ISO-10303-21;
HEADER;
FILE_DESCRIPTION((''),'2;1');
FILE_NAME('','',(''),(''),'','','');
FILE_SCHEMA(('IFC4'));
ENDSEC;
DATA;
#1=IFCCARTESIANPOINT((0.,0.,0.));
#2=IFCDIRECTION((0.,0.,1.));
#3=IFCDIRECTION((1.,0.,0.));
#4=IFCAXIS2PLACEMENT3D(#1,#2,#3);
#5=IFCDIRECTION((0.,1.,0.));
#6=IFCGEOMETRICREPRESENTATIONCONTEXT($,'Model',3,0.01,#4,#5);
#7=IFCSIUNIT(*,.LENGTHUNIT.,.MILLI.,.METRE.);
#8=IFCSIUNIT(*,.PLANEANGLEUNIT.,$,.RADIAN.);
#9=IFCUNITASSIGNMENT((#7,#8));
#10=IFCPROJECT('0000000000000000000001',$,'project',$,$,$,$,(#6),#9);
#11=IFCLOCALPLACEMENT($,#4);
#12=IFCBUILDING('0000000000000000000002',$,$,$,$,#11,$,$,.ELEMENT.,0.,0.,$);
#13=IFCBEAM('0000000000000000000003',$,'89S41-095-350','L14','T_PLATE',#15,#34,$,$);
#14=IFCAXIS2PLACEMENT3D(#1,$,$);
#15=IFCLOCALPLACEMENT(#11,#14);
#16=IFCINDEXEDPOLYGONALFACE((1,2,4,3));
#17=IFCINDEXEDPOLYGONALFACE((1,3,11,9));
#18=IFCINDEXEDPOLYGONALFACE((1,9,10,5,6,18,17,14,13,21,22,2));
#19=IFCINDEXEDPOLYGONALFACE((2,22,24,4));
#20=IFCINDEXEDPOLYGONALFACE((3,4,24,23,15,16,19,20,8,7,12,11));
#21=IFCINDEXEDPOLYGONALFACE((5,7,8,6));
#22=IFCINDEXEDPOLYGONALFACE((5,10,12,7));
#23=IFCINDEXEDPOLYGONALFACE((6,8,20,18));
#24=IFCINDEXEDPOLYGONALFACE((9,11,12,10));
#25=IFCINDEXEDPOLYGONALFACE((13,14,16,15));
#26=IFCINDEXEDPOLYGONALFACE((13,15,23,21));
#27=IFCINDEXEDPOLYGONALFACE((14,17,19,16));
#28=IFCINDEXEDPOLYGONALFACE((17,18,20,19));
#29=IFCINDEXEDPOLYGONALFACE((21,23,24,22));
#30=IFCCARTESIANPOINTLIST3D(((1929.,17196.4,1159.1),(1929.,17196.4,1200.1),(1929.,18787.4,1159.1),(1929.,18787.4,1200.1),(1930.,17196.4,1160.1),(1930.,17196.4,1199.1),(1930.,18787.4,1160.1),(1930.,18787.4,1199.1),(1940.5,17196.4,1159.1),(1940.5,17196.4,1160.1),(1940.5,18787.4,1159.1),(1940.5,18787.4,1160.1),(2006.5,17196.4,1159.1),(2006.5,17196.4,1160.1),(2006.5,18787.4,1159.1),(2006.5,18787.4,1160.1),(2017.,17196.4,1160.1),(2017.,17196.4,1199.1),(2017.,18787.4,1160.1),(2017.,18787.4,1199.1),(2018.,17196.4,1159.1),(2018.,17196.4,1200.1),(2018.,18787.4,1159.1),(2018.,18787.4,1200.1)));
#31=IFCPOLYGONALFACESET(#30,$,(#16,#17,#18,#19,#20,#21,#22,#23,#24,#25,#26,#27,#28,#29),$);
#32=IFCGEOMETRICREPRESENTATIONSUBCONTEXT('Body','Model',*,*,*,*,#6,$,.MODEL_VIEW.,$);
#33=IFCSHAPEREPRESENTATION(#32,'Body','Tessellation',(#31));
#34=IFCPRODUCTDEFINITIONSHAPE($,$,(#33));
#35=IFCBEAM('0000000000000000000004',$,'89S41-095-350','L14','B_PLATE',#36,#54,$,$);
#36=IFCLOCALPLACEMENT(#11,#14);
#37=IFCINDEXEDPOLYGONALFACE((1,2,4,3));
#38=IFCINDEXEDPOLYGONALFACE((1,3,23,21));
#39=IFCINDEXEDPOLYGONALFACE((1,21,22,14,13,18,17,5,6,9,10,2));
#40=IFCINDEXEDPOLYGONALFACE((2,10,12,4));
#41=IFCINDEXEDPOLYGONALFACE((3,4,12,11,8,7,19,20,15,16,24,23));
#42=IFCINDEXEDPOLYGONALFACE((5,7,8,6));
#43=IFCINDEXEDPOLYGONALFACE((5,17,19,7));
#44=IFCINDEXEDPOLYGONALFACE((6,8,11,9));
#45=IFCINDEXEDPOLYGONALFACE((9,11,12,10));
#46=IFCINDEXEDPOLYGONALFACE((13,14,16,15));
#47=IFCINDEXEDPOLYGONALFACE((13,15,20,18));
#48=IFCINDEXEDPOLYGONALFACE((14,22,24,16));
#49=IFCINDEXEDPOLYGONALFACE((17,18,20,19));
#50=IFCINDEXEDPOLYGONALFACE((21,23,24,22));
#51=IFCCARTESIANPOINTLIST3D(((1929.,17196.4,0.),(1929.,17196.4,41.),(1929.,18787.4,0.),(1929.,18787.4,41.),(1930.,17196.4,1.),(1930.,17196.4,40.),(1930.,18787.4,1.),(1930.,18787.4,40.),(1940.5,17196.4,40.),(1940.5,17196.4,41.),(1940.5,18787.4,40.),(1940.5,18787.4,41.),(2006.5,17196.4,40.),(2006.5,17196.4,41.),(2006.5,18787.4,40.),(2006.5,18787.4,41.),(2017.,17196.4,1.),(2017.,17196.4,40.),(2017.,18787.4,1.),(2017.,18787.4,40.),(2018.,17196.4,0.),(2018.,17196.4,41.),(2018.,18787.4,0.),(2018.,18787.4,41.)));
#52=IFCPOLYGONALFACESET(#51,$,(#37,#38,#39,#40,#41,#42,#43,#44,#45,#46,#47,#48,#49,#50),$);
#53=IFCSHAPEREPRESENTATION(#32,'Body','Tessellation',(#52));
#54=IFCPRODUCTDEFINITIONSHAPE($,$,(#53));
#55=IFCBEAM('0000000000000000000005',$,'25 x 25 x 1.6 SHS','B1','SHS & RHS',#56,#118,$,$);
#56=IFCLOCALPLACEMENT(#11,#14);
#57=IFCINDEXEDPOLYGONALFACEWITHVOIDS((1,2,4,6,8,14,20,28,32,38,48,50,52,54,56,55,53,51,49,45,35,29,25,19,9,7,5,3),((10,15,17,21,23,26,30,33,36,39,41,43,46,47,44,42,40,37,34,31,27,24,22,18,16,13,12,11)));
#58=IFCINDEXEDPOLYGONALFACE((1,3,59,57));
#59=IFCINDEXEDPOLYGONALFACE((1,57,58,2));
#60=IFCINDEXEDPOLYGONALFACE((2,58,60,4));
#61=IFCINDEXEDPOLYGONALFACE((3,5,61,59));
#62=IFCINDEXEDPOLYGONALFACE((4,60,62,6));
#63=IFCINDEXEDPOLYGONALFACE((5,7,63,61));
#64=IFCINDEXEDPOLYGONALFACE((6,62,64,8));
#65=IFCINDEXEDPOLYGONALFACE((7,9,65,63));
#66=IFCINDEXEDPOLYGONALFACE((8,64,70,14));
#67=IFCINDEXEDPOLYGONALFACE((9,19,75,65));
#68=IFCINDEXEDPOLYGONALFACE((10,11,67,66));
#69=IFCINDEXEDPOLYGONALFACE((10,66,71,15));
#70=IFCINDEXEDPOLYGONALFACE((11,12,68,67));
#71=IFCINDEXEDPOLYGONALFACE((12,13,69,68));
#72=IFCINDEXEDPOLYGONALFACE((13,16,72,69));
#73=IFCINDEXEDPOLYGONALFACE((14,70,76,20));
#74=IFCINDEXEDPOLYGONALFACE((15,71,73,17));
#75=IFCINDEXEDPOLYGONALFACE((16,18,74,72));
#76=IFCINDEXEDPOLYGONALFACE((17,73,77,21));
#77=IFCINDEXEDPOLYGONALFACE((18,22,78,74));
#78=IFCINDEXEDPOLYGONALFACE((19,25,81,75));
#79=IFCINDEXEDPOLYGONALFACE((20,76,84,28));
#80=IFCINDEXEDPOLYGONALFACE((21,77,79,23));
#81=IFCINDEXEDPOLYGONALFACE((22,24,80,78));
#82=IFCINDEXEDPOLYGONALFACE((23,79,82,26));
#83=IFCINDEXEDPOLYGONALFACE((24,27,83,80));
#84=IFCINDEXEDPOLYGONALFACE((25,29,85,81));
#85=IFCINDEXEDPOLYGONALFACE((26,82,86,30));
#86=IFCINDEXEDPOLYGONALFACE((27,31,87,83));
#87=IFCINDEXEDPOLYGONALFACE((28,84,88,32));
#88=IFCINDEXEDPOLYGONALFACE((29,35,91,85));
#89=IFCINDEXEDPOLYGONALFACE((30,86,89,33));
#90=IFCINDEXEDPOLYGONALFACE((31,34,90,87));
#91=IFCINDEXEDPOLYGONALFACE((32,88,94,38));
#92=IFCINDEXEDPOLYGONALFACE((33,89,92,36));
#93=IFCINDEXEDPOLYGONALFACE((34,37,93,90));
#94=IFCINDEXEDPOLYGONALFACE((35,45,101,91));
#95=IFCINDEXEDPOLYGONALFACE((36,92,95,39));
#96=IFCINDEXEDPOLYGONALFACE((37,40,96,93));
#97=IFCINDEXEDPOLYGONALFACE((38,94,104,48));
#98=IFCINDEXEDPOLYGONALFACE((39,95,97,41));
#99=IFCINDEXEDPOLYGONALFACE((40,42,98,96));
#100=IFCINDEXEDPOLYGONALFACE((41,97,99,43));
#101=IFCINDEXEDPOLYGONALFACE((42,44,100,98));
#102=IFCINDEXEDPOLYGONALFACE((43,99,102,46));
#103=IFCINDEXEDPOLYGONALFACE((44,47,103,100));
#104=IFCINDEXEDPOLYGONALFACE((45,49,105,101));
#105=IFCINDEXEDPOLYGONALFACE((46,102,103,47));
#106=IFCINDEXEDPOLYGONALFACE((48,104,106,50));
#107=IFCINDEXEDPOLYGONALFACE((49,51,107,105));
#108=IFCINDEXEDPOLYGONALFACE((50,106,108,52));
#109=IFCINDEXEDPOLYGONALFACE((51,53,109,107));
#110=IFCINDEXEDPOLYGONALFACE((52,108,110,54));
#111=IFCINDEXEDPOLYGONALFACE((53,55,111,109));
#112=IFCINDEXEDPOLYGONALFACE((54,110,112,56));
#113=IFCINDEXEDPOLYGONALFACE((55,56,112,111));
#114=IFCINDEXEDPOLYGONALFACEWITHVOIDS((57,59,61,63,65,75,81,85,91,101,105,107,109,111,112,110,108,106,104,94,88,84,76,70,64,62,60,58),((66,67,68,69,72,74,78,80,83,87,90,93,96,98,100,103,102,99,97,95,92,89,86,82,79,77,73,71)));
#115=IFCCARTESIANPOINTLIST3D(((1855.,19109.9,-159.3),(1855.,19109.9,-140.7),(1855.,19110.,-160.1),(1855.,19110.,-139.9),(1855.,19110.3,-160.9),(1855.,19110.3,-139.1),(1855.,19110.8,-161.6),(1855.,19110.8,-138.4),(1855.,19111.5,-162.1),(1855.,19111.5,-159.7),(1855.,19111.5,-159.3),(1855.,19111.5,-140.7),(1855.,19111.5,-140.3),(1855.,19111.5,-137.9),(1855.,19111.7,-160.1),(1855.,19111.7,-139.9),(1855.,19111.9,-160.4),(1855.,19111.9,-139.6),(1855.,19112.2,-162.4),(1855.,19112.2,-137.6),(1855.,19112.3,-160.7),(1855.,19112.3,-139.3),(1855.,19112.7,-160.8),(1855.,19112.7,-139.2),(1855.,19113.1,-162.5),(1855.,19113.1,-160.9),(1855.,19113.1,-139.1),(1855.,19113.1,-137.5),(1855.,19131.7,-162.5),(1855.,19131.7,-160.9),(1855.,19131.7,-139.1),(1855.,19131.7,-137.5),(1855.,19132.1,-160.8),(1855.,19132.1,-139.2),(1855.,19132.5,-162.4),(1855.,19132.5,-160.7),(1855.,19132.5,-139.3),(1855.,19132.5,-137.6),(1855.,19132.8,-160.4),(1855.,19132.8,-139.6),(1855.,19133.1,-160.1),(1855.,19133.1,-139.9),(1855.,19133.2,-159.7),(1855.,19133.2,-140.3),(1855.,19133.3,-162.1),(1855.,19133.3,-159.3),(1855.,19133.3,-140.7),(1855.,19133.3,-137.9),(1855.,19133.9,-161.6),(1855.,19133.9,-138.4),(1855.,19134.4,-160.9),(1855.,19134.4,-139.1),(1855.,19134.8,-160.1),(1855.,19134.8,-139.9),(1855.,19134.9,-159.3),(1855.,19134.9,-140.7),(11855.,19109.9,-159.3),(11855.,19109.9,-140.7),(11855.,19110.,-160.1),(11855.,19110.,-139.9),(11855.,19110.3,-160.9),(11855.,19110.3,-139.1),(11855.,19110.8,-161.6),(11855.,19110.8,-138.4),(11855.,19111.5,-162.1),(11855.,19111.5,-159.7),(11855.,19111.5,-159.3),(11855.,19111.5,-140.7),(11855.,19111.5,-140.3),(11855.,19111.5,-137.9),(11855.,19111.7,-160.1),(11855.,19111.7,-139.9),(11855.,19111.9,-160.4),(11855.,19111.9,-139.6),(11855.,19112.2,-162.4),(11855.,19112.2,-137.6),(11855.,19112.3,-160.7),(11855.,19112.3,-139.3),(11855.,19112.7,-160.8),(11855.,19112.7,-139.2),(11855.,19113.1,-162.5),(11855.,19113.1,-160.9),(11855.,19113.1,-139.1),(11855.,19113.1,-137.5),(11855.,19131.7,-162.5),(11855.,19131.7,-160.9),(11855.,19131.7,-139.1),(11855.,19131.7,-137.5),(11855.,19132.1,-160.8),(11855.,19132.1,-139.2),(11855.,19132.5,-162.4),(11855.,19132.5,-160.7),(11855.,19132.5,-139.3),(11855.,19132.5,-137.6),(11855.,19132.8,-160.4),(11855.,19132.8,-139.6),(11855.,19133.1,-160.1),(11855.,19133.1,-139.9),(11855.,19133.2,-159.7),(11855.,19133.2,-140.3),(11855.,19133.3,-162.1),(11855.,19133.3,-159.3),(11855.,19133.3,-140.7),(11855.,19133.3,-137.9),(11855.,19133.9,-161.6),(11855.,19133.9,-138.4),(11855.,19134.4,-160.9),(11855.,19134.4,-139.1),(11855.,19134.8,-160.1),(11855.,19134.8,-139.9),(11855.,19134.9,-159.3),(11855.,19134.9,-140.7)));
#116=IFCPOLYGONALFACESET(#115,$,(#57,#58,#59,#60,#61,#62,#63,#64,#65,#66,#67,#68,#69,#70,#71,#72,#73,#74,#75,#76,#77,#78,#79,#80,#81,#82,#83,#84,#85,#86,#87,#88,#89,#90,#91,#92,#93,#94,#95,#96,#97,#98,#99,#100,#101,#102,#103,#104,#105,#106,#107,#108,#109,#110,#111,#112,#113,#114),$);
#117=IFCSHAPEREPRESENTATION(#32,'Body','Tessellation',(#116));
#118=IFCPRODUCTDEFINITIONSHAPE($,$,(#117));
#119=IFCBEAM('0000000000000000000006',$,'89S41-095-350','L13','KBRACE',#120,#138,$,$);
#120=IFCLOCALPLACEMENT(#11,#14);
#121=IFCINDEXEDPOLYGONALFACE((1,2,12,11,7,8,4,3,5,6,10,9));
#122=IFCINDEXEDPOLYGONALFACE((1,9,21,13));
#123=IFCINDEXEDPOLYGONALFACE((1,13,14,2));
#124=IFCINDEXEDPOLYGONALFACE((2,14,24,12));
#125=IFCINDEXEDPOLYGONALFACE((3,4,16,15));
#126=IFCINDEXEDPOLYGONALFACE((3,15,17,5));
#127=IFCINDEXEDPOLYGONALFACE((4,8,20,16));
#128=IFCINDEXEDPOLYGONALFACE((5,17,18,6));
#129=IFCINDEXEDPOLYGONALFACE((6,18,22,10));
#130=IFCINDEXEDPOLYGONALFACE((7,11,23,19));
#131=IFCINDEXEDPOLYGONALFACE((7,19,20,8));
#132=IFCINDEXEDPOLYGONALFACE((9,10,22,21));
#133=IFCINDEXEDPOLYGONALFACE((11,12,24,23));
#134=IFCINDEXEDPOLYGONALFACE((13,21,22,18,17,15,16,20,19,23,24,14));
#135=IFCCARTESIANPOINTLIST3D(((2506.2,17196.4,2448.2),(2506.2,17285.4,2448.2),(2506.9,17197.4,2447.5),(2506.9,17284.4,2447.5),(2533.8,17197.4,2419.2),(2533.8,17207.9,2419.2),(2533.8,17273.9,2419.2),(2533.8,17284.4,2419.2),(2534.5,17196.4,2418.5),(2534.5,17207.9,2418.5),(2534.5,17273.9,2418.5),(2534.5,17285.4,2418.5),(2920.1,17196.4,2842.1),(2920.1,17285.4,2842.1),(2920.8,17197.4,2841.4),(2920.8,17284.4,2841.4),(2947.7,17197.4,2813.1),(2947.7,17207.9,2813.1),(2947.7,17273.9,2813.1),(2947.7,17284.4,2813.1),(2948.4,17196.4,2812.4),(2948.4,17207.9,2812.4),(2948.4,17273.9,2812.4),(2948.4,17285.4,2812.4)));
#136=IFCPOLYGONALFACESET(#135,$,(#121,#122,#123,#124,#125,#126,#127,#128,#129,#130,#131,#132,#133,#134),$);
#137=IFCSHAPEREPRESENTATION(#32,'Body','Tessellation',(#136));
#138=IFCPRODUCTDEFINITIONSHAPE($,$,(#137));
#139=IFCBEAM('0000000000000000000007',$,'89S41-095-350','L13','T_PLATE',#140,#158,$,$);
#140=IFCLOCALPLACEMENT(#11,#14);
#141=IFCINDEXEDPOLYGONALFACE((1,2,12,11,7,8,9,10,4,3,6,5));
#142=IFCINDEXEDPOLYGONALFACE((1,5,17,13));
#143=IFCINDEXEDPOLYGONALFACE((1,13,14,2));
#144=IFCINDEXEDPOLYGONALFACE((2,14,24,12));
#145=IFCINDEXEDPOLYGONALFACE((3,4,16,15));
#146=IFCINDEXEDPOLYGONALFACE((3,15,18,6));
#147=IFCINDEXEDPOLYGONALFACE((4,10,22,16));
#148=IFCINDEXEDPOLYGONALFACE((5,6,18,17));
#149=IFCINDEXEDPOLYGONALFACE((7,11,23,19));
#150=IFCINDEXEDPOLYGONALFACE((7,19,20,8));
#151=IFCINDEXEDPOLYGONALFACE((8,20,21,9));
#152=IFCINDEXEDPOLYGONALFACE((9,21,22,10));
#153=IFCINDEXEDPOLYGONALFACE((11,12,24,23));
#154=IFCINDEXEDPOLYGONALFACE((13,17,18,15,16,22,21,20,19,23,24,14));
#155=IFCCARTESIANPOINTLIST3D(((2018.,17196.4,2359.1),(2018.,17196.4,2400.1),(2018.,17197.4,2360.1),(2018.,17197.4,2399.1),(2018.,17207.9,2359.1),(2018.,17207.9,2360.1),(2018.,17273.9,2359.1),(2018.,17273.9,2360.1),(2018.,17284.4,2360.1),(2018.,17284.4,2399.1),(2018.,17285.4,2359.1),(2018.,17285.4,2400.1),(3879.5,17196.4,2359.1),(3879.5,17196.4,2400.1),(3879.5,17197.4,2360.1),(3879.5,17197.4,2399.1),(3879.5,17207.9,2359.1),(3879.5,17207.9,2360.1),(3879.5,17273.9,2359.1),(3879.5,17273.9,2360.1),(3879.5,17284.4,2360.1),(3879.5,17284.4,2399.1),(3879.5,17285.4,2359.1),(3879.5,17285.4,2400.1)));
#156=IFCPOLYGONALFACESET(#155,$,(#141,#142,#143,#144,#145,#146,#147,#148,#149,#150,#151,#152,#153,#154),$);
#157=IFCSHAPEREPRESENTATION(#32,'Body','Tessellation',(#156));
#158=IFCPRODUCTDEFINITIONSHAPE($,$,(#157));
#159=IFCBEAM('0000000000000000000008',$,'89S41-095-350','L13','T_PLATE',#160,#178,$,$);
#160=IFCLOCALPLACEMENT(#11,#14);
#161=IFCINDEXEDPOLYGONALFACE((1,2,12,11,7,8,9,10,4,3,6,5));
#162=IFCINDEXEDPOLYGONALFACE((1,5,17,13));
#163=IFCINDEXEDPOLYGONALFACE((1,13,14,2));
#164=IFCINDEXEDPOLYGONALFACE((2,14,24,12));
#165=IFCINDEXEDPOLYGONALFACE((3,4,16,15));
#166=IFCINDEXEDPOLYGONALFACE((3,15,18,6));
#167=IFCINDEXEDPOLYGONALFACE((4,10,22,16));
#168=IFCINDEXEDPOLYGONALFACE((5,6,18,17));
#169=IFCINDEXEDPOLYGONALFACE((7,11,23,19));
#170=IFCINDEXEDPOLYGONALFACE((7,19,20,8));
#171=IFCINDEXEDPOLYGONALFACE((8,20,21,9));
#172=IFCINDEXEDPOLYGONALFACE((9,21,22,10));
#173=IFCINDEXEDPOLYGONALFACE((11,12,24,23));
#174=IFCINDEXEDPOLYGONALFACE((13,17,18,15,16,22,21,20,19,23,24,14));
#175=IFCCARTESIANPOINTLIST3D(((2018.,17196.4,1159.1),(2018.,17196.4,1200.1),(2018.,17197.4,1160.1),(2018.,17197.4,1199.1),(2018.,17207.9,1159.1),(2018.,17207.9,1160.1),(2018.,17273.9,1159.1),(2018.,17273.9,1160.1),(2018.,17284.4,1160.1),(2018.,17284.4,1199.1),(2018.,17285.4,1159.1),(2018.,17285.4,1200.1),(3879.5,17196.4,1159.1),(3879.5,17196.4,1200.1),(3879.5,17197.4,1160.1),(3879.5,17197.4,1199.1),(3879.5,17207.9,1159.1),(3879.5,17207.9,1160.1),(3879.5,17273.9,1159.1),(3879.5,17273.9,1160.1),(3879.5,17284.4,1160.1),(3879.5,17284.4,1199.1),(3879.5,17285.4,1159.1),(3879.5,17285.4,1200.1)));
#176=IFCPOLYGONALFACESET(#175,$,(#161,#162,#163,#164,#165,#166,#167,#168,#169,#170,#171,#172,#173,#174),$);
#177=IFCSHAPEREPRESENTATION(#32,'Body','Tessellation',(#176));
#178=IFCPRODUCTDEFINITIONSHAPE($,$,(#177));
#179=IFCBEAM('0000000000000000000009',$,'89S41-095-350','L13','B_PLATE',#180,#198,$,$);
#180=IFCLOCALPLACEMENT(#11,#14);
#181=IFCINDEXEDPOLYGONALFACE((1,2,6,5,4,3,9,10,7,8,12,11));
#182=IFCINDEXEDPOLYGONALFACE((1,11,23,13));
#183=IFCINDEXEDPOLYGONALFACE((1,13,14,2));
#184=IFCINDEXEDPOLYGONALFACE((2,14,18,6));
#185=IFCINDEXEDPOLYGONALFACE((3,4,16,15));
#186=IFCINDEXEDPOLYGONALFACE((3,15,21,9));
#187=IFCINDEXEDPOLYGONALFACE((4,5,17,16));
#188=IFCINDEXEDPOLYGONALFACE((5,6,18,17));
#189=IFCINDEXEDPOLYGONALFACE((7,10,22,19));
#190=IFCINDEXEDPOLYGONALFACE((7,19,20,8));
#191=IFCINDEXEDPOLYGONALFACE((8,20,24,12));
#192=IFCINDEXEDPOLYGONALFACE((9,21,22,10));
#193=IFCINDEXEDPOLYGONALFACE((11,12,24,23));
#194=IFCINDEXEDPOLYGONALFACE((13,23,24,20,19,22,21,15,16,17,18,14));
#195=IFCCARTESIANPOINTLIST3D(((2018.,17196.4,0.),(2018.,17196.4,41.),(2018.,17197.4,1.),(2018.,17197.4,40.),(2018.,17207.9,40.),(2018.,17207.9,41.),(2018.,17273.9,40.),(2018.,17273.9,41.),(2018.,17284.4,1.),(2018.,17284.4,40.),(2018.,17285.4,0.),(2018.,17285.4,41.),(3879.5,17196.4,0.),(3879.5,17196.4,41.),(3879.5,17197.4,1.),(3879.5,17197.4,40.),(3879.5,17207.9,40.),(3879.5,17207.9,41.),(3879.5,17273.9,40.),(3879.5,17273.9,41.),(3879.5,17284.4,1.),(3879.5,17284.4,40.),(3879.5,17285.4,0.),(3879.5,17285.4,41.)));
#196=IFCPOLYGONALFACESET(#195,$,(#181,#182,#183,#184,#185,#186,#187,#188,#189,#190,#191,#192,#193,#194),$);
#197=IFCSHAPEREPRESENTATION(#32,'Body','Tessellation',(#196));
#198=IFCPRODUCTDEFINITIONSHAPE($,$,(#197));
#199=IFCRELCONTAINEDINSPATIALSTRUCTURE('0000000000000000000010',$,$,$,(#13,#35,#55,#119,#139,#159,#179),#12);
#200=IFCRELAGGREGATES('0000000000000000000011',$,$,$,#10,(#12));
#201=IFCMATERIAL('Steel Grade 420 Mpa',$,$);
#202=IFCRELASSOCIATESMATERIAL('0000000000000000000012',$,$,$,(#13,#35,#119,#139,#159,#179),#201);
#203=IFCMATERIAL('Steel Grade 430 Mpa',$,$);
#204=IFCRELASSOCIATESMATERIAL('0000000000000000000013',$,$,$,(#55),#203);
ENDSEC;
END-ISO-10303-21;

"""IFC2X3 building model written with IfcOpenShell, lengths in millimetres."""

from ifc_helpers import new_model, si_unit, direction, frame, origin, origin_with_axes, origin_2d_with_axis, place, context, subcontext, project, spatial, hollow_rectangle, c_section, extrude, source, transform, mapped, material, element, save


model = new_model("IFC2X3")

# Units and contexts
model_context = context("Model", 3, precision=0.01, world=origin_with_axes(), true_north=direction((0.0, 1.0, 0.0)))
body_context = subcontext(model_context, "Body", "Model", "MODEL_VIEW")
ifc_project = project(units=[si_unit("LENGTHUNIT", "METRE", prefix="MILLI"), si_unit("PLANEANGLEUNIT", "RADIAN")], contexts=[model_context])

# Building
building_placement = place(None, origin_with_axes())
building = spatial("IfcBuilding", under=ifc_project, at=building_placement, CompositionType="ELEMENT", ElevationOfRefHeight=0.0, ElevationOfTerrain=0.0)

# Shared definitions
ifc_material_1 = material(Name="Steel Grade 420 Mpa")

# Beams
shared_shape_1 = source(origin(), body_context, "Body", "SweptSolid", [
    extrude(c_section(Depth=89.0, Width=41.0, WallThickness=1.0, Girth=11.5, at=origin_2d_with_axis()), origin_with_axes(), (0.0, 0.0, 1.0), 1591.0),
])
beam_1_placement = place(None, frame((1973.5, 18787.4, 1179.6), z_axis=(0.0, -1.0, 0.0), x_axis=(0.0, 0.0, -1.0)))
element("IfcBeam", 1, at=beam_1_placement, inside=building, material=ifc_material_1, Name="89S41-095-350", Description="L14", ObjectType="T_PLATE", context=body_context, shape_type="MappedRepresentation", body=[
    mapped(shared_shape_1, transform((0.0, 0.0, 0.0), scale=1.0)),
])
shared_shape_2 = source(origin(), body_context, "Body", "SweptSolid", [
    extrude(c_section(Depth=89.0, Width=41.0, WallThickness=1.0, Girth=11.5, at=origin_2d_with_axis()), origin_with_axes(), (0.0, 0.0, 1.0), 1591.0),
])
beam_2_placement = place(None, frame((1973.5, 18787.4, 20.5), z_axis=(0.0, -1.0, 0.0), x_axis=(0.0, 0.0, 1.0)))
element("IfcBeam", 2, at=beam_2_placement, inside=building, material=ifc_material_1, Name="89S41-095-350", Description="L14", ObjectType="B_PLATE", context=body_context, shape_type="MappedRepresentation", body=[
    mapped(shared_shape_2, transform((0.0, 0.0, 0.0), scale=1.0)),
])
ifc_material_2 = material(Name="Steel Grade 430 Mpa")
shared_shape_3 = source(origin(), body_context, "Body", "SweptSolid", [
    extrude(hollow_rectangle(XDim=25.0, YDim=25.0, WallThickness=1.6, InnerFilletRadius=1.6, OuterFilletRadius=3.2, at=origin_2d_with_axis()), origin_with_axes(), (0.0, 0.0, 1.0), 10000.0),
])
beam_3_placement = place(None, frame((1855.0, 19122.4, -150.0), z_axis=(1.0, 0.0, 0.0), x_axis=(0.0, 1.0, 0.0)))
element("IfcBeam", 3, at=beam_3_placement, inside=building, material=ifc_material_2, Name="25 x 25 x 1.6 SHS", Description="B1", ObjectType="SHS & RHS", context=body_context, shape_type="MappedRepresentation", body=[
    mapped(shared_shape_3, transform((0.0, 0.0, 0.0), scale=1.0)),
])
shared_shape_4 = source(origin(), body_context, "Body", "SweptSolid", [
    extrude(c_section(Depth=89.0, Width=41.0, WallThickness=1.0, Girth=11.5, at=origin_2d_with_axis()), origin_with_axes(), (0.0, 0.0, 1.0), 571.4),
])
beam_4_placement = place(None, frame((2520.3, 17240.9, 2433.3), z_axis=(0.724398, 0.0, 0.689382), x_axis=(0.689382, 0.0, -0.724398)))
element("IfcBeam", 4, at=beam_4_placement, inside=building, material=ifc_material_1, Name="89S41-095-350", Description="L13", ObjectType="KBRACE", context=body_context, shape_type="MappedRepresentation", body=[
    mapped(shared_shape_4, transform((0.0, 0.0, 0.0), scale=1.0)),
])
shared_shape_5 = source(origin(), body_context, "Body", "SweptSolid", [
    extrude(c_section(Depth=89.0, Width=41.0, WallThickness=1.0, Girth=11.5, at=origin_2d_with_axis()), origin_with_axes(), (0.0, 0.0, 1.0), 1861.5),
])
beam_5_placement = place(None, frame((2018.0, 17240.9, 2379.6), z_axis=(1.0, 0.0, 0.0), x_axis=(0.0, 0.0, -1.0)))
element("IfcBeam", 5, at=beam_5_placement, inside=building, material=ifc_material_1, Name="89S41-095-350", Description="L13", ObjectType="T_PLATE", context=body_context, shape_type="MappedRepresentation", body=[
    mapped(shared_shape_5, transform((0.0, 0.0, 0.0), scale=1.0)),
])
shared_shape_6 = source(origin(), body_context, "Body", "SweptSolid", [
    extrude(c_section(Depth=89.0, Width=41.0, WallThickness=1.0, Girth=11.5, at=origin_2d_with_axis()), origin_with_axes(), (0.0, 0.0, 1.0), 1861.5),
])
beam_6_placement = place(None, frame((2018.0, 17240.9, 1179.6), z_axis=(1.0, 0.0, 0.0), x_axis=(0.0, 0.0, -1.0)))
element("IfcBeam", 6, at=beam_6_placement, inside=building, material=ifc_material_1, Name="89S41-095-350", Description="L13", ObjectType="T_PLATE", context=body_context, shape_type="MappedRepresentation", body=[
    mapped(shared_shape_6, transform((0.0, 0.0, 0.0), scale=1.0)),
])
shared_shape_7 = source(origin(), body_context, "Body", "SweptSolid", [
    extrude(c_section(Depth=89.0, Width=41.0, WallThickness=1.0, Girth=11.5, at=origin_2d_with_axis()), origin_with_axes(), (0.0, 0.0, 1.0), 1861.5),
])
beam_7_placement = place(None, frame((2018.0, 17240.9, 20.5), z_axis=(1.0, 0.0, 0.0), x_axis=(0.0, 0.0, 1.0)))
element("IfcBeam", 7, at=beam_7_placement, inside=building, material=ifc_material_1, Name="89S41-095-350", Description="L13", ObjectType="B_PLATE", context=body_context, shape_type="MappedRepresentation", body=[
    mapped(shared_shape_7, transform((0.0, 0.0, 0.0), scale=1.0)),
])

save(model, "model.ifc")
